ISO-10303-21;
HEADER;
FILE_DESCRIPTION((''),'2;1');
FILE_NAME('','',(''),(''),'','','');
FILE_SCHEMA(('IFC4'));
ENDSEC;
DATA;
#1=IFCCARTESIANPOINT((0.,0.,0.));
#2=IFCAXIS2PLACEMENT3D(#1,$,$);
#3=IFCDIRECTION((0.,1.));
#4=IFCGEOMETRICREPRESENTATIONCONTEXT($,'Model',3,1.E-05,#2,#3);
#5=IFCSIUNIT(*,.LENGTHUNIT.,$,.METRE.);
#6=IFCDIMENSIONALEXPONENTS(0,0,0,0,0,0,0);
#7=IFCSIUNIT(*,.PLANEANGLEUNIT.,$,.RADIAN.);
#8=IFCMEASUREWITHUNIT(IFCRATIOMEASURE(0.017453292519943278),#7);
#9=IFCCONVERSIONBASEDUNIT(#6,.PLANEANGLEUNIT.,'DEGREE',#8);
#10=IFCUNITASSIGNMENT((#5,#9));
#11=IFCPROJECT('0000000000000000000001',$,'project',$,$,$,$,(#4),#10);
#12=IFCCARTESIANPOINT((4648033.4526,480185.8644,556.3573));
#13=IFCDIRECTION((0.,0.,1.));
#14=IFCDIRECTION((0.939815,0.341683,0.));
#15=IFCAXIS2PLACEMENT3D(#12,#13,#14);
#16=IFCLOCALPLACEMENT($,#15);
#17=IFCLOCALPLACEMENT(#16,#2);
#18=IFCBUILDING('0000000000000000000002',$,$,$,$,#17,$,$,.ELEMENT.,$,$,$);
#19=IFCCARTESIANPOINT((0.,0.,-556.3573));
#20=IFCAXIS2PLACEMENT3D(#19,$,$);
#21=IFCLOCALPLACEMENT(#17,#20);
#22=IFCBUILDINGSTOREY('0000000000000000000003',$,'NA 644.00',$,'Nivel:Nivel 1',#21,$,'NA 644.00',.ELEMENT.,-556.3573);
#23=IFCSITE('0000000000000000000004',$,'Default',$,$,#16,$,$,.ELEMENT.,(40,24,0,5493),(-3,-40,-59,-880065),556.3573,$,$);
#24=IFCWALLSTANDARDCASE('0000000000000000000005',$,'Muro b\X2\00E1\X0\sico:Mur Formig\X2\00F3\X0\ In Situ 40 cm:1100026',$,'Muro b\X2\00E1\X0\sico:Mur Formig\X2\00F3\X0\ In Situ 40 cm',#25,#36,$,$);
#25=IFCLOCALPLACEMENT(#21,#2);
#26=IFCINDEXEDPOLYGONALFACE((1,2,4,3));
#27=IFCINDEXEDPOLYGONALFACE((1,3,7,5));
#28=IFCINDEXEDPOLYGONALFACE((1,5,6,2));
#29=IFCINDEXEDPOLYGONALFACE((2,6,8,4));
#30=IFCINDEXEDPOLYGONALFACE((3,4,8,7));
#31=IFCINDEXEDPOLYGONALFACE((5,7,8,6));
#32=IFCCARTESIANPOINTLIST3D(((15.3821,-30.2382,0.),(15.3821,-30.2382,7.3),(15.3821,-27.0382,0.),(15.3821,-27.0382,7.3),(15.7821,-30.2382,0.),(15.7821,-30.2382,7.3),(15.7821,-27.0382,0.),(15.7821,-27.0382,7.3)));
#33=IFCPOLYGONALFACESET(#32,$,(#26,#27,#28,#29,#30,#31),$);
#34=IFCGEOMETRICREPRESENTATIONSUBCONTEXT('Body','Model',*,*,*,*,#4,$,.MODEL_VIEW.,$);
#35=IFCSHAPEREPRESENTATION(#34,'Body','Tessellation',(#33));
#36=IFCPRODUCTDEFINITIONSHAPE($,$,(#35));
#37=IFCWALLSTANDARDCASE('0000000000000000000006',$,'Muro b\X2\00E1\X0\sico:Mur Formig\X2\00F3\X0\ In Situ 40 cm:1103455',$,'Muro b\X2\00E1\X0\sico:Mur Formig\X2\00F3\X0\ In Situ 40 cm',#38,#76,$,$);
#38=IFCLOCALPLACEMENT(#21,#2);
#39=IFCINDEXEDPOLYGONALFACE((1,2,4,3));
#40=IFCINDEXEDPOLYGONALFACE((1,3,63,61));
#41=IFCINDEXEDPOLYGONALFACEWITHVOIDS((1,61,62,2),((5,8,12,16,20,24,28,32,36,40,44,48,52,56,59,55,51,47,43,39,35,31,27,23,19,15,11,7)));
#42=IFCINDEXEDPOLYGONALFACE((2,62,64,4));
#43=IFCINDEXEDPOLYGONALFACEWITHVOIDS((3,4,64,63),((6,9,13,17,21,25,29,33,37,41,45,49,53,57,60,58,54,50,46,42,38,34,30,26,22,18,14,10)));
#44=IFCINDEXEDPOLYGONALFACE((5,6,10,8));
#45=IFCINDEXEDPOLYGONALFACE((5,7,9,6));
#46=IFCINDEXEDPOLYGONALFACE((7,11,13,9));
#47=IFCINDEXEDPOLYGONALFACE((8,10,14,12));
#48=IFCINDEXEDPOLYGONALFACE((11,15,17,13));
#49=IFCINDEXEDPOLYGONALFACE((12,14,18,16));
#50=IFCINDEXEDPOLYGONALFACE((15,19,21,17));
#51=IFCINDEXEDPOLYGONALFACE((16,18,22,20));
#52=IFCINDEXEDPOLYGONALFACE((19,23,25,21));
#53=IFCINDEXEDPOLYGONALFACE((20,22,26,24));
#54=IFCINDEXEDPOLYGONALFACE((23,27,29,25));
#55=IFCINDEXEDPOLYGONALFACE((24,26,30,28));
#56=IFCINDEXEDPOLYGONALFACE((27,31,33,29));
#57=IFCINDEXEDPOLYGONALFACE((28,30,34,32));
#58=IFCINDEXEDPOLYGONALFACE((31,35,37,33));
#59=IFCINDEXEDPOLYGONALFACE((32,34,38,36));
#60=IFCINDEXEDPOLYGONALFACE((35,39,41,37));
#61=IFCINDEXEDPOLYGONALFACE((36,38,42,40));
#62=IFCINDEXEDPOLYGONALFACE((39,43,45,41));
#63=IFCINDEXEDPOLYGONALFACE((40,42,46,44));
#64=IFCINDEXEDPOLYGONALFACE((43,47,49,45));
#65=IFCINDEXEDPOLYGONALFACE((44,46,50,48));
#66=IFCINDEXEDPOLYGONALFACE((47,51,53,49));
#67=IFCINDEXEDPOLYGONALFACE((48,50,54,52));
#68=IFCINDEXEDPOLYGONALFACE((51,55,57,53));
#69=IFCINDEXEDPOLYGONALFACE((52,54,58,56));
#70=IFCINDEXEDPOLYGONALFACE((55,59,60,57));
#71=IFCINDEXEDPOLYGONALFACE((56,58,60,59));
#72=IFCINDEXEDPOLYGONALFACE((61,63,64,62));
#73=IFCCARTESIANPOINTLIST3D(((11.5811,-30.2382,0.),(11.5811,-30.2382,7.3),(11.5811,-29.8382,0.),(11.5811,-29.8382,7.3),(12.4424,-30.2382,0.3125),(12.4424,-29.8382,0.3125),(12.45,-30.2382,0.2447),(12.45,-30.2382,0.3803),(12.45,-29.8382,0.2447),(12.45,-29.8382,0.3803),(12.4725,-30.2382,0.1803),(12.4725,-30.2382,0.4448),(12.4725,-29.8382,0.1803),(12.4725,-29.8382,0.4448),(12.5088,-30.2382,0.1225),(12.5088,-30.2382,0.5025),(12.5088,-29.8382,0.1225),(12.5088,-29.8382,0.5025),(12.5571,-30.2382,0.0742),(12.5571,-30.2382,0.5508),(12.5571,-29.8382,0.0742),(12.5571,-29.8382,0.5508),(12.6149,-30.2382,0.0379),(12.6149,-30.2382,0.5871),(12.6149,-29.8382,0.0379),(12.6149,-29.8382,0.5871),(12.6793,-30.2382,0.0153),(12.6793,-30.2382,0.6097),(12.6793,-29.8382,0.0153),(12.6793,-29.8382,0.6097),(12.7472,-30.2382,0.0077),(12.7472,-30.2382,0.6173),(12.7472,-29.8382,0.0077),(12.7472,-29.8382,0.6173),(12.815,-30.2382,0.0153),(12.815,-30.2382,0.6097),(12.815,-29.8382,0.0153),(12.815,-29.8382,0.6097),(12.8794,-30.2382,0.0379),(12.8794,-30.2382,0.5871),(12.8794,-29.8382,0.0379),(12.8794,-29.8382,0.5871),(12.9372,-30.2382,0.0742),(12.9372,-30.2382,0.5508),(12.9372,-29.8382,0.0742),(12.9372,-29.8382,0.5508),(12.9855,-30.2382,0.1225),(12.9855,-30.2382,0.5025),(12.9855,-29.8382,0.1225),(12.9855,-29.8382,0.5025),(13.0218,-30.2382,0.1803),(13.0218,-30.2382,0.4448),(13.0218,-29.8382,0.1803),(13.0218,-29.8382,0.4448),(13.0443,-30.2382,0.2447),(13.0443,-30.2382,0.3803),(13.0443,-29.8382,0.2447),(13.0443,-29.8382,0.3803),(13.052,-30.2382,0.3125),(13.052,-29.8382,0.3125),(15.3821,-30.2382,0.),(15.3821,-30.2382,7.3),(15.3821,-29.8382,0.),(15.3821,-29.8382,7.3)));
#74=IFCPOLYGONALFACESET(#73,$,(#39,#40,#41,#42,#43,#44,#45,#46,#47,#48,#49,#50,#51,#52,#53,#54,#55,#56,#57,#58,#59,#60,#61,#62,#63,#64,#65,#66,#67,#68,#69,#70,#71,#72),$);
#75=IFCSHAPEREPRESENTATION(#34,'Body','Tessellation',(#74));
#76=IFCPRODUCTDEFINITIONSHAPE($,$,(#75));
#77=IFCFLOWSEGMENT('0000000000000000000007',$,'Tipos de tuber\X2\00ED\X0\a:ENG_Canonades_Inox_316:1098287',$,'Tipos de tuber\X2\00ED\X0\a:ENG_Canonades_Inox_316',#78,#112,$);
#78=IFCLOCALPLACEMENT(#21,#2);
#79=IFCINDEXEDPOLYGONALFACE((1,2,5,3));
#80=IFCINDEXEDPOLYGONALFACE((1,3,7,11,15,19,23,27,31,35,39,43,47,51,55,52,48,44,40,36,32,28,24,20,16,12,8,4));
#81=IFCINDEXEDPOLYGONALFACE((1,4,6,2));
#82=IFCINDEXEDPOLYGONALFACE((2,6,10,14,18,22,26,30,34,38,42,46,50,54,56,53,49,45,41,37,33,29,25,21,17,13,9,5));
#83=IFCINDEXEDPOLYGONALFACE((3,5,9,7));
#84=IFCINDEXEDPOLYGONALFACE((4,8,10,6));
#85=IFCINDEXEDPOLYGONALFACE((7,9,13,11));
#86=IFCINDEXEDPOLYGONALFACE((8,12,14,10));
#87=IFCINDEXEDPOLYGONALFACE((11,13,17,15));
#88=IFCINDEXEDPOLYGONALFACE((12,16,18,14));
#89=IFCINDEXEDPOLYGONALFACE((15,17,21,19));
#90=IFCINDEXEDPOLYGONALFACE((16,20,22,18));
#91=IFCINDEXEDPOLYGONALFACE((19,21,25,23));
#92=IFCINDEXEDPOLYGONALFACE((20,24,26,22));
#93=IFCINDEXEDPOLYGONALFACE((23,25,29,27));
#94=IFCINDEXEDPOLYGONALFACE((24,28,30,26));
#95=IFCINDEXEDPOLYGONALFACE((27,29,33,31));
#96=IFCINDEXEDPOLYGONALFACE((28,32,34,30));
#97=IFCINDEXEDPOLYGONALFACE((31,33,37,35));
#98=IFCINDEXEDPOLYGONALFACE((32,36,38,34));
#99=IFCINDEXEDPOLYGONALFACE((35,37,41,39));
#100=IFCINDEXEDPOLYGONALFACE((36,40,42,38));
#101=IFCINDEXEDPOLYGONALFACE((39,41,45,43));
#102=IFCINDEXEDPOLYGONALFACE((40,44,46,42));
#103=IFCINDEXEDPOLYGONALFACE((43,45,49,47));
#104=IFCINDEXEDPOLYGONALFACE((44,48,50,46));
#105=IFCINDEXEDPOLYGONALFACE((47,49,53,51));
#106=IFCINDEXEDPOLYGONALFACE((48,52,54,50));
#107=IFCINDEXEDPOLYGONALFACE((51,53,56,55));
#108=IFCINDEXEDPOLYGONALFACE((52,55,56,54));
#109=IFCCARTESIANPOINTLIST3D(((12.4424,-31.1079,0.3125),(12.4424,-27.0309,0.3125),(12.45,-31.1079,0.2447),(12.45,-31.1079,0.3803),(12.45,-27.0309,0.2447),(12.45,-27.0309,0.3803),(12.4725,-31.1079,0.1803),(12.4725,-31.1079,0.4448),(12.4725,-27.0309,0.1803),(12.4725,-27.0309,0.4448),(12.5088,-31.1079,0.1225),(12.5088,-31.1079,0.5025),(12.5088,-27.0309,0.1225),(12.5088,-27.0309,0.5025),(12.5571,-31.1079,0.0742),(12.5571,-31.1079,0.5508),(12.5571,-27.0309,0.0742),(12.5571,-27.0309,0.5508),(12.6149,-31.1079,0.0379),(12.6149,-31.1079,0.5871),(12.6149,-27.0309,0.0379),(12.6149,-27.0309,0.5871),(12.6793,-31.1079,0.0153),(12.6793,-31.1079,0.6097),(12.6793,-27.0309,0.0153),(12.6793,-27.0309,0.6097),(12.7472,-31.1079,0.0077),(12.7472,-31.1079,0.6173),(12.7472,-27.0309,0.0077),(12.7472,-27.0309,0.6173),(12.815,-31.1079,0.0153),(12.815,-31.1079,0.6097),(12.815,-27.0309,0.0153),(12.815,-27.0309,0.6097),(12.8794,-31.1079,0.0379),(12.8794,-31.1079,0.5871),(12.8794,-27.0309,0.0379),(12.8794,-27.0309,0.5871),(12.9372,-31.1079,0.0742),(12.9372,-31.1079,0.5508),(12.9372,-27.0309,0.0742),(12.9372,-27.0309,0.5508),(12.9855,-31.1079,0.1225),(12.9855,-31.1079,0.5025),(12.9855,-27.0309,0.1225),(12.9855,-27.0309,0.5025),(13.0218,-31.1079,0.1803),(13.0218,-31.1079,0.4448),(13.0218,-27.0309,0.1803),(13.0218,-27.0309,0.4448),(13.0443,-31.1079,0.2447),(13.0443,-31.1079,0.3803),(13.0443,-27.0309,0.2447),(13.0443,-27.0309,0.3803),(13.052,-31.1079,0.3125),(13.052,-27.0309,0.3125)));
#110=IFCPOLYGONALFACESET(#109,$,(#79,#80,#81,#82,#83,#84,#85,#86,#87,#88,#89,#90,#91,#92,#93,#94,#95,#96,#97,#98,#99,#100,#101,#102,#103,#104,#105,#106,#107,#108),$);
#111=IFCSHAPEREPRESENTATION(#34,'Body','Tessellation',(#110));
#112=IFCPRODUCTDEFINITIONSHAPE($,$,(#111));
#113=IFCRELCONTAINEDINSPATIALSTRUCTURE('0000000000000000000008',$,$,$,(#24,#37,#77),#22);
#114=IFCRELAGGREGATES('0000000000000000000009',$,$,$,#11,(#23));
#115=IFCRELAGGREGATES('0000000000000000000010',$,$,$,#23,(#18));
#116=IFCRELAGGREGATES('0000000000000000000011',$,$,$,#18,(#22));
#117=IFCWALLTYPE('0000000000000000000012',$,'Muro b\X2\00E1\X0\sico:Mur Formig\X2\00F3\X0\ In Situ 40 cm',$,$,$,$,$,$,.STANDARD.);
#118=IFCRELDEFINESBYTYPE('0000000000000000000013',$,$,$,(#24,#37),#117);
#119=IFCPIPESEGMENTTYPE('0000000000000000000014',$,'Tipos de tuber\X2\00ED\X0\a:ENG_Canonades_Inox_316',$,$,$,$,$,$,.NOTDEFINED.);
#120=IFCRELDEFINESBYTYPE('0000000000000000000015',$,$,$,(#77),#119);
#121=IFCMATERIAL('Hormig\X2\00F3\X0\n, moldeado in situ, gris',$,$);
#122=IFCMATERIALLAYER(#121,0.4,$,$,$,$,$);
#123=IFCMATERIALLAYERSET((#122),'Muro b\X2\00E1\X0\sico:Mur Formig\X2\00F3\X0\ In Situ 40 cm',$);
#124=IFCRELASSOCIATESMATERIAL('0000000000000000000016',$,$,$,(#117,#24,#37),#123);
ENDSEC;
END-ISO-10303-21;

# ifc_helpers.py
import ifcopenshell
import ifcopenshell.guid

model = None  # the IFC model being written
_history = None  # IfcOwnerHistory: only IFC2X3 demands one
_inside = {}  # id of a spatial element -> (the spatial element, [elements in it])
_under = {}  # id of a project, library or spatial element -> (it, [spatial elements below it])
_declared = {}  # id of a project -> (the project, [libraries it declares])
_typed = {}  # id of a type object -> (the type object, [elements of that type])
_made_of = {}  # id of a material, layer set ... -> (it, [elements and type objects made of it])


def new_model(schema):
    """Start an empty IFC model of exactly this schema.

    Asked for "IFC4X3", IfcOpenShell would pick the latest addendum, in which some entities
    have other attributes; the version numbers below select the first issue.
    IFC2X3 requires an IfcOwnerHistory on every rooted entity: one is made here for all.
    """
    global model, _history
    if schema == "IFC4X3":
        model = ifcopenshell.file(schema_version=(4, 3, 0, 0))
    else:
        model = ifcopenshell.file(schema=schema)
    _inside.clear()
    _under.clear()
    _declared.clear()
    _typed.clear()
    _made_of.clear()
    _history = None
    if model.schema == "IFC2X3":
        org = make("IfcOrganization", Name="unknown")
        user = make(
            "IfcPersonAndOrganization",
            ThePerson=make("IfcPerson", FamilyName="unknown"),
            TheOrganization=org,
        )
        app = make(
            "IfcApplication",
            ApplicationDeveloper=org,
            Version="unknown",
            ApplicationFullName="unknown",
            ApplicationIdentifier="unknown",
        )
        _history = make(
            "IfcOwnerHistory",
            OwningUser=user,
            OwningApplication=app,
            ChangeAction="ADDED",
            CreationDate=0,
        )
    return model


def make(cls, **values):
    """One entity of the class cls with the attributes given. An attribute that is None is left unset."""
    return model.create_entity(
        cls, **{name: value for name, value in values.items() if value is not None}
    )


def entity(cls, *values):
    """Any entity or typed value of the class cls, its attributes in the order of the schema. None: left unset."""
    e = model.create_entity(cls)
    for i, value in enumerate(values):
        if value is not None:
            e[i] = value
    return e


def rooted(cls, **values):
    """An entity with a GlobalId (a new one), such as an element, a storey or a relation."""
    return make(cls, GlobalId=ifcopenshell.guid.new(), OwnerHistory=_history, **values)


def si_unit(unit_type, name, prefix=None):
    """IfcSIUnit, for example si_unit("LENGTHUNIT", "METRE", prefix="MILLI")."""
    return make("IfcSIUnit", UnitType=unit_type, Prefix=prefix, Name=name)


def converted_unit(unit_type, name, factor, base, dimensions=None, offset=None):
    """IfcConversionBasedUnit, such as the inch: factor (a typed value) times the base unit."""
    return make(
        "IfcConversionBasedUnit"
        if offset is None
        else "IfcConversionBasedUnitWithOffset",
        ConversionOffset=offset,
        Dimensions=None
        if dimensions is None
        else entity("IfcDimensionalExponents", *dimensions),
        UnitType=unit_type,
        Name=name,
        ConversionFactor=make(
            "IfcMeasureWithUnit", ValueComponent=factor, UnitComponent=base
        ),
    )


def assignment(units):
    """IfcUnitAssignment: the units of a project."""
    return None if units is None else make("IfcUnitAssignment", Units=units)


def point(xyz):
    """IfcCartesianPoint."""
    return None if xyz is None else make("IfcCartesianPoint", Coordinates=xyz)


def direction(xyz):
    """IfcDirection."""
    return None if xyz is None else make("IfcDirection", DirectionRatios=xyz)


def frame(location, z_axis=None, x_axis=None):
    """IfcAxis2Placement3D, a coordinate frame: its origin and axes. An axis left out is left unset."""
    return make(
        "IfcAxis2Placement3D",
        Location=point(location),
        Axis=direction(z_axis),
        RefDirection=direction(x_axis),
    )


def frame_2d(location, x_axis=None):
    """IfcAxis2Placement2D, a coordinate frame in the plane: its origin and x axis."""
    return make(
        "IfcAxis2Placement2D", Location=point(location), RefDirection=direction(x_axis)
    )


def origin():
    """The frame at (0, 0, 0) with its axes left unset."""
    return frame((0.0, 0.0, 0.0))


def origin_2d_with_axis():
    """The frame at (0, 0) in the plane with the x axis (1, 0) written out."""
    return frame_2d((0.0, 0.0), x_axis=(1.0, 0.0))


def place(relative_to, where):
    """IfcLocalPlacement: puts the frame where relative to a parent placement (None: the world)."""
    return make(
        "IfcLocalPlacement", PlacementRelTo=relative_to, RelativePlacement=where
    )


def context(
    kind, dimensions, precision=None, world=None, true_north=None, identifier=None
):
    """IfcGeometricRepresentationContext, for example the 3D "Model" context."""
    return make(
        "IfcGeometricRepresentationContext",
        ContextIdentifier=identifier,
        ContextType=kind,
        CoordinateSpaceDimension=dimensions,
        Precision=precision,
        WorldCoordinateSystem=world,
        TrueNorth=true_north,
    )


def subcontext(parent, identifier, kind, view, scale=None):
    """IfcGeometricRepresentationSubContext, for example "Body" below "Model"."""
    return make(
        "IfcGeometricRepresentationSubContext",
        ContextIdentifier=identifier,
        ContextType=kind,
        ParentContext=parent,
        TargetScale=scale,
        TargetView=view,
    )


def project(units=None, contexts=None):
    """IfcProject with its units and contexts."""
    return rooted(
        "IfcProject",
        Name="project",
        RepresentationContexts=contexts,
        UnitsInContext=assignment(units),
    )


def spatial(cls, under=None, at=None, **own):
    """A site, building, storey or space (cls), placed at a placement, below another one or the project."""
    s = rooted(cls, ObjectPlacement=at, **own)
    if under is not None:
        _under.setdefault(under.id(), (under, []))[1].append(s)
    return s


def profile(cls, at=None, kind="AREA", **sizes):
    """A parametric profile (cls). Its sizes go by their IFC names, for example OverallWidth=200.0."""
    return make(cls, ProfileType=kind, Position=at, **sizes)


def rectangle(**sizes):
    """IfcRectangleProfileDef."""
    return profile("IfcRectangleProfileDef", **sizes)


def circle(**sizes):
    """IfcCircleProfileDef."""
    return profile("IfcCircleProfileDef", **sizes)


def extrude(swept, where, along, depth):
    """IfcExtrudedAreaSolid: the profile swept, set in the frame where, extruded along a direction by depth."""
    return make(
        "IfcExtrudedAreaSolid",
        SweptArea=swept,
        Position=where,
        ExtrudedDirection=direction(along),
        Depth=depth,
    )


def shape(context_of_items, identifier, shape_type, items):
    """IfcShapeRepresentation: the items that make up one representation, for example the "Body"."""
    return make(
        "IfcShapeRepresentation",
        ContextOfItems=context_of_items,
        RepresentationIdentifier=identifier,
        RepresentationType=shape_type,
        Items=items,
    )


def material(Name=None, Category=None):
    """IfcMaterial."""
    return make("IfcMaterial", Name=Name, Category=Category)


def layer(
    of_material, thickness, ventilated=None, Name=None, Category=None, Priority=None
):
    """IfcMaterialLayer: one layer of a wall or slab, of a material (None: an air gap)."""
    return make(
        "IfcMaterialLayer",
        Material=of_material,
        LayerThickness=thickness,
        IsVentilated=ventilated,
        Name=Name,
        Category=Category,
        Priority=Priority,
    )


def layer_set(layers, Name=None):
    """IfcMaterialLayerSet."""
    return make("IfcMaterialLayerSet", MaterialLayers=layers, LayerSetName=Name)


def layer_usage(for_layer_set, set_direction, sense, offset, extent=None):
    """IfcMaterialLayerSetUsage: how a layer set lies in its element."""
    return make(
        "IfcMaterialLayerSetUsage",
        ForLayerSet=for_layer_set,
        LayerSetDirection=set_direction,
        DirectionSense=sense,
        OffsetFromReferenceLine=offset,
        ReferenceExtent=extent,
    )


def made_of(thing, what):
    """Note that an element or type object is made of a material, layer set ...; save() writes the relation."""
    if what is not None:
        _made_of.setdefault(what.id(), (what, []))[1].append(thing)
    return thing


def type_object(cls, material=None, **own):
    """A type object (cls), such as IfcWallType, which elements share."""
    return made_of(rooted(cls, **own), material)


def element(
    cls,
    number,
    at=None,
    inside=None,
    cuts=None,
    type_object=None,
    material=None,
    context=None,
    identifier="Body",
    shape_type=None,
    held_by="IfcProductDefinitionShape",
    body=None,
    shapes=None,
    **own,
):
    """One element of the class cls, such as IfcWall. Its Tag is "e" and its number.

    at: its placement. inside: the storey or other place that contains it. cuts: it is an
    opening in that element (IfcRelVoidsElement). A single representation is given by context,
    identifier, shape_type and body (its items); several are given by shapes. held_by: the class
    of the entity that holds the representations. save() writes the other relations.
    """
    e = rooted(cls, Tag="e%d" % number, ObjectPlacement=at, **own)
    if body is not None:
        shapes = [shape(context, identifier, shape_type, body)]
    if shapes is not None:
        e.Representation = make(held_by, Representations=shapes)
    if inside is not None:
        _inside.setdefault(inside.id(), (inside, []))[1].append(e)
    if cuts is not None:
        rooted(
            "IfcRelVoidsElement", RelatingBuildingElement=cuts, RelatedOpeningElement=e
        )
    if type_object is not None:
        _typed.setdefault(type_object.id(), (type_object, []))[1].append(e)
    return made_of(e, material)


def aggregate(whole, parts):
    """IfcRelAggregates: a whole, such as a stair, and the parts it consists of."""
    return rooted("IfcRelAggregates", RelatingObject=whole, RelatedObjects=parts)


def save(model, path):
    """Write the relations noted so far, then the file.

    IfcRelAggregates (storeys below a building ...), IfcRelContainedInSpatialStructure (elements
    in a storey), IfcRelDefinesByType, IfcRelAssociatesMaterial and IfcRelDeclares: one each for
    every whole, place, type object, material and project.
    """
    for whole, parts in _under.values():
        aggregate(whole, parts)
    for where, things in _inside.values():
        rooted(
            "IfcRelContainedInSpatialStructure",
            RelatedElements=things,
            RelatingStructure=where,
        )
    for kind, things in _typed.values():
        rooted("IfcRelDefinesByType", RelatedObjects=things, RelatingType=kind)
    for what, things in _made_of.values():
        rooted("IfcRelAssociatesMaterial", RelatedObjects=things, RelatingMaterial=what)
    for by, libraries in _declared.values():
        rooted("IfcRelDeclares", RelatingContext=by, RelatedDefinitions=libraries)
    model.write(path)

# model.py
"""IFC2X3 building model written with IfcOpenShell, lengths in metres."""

from ifc_helpers import new_model, entity, si_unit, converted_unit, direction, frame, frame_2d, origin, origin_2d_with_axis, place, context, subcontext, project, spatial, rectangle, circle, extrude, material, layer, layer_set, layer_usage, type_object, element, save


model = new_model("IFC2X3")

# Units and contexts
model_context = context("Model", 3, precision=1e-05, world=origin(), true_north=direction((0.0, 1.0)))
body_context = subcontext(model_context, "Body", "Model", "MODEL_VIEW")
ifc_project = project(units=[si_unit("LENGTHUNIT", "METRE"), converted_unit("PLANEANGLEUNIT", "DEGREE", entity("IfcRatioMeasure", 0.017453292519943278), si_unit("PLANEANGLEUNIT", "RADIAN"), dimensions=[0, 0, 0, 0, 0, 0, 0])], contexts=[model_context])

# Site, building, storey
site_placement = place(None, frame((4648033.4526, 480185.8644, 556.3573), z_axis=(0.0, 0.0, 1.0), x_axis=(0.939815, 0.341683, 0.0)))
site = spatial("IfcSite", under=ifc_project, at=site_placement, Name="Default", CompositionType="ELEMENT", RefLatitude=(40, 24, 0, 5493), RefLongitude=(-3, -40, -59, -880065), RefElevation=556.3573)
building_placement = place(site_placement, origin())
building = spatial("IfcBuilding", under=site, at=building_placement, CompositionType="ELEMENT")
storey_placement = place(building_placement, frame((0.0, 0.0, -556.3573)))
storey = spatial("IfcBuildingStorey", under=building, at=storey_placement, Name="NA 644.00", ObjectType="Nivel:Nivel 1", LongName="NA 644.00", CompositionType="ELEMENT", Elevation=-556.3573)

# Shared definitions
ifc_material_1 = material(Name="Hormigón, moldeado in situ, gris")

# Shared definitions
ifc_layer_1 = layer(ifc_material_1, 0.4)
ifc_layer_set_1 = layer_set([ifc_layer_1], Name="Muro básico:Mur Formigó In Situ 40 cm")
wall_type = type_object("IfcWallType", Name="Muro básico:Mur Formigó In Situ 40 cm", PredefinedType="STANDARD", material=ifc_layer_set_1)

# Wall
ifc_layer_usage_1 = layer_usage(ifc_layer_set_1, "AXIS2", "NEGATIVE", 0.2)
wall_1_placement = place(storey_placement, frame((15.5821, -27.0382, 0.0), z_axis=(0.0, 0.0, 1.0), x_axis=(0.0, -1.0, 0.0)))
element("IfcWallStandardCase", 1, at=wall_1_placement, inside=storey, type_object=wall_type, material=ifc_layer_usage_1, Name="Muro básico:Mur Formigó In Situ 40 cm:1100026", ObjectType="Muro básico:Mur Formigó In Situ 40 cm", context=body_context, shape_type="SweptSolid", body=[
    extrude(rectangle(XDim=3.2, YDim=0.4, at=frame_2d((1.6, 0.0), x_axis=(-1.0, 0.0))), origin(), (0.0, 0.0, 1.0), 7.3),
])

# Wall, opening
ifc_layer_usage_2 = layer_usage(ifc_layer_set_1, "AXIS2", "NEGATIVE", 0.2)
wall_2_placement = place(storey_placement, frame((11.5811, -30.0382, 0.0)))
wall_2 = element("IfcWallStandardCase", 2, at=wall_2_placement, inside=storey, type_object=wall_type, material=ifc_layer_usage_2, Name="Muro básico:Mur Formigó In Situ 40 cm:1103455", ObjectType="Muro básico:Mur Formigó In Situ 40 cm", context=body_context, shape_type="SweptSolid", body=[
    extrude(rectangle(XDim=3.801, YDim=0.4, at=frame_2d((1.9005, 0.0), x_axis=(-1.0, 0.0))), origin(), (0.0, 0.0, 1.0), 7.3),
])
opening_1_placement = place(wall_2_placement, origin())
element("IfcOpeningElement", 3, at=opening_1_placement, cuts=wall_2, ObjectType="Opening", context=body_context, shape_type="SweptSolid", body=[
    extrude(circle(Radius=0.3048, at=origin_2d_with_axis()), frame((1.166, 0.2, 0.3125), z_axis=(0.0, -1.0, 0.0), x_axis=(-1.0, 0.0, 0.0)), (0.0, 0.0, 1.0), 0.4),
])

# Flow segment
pipe_segment_type = type_object("IfcPipeSegmentType", Name="Tipos de tubería:ENG_Canonades_Inox_316", PredefinedType="NOTDEFINED")
flow_segment_placement = place(storey_placement, origin())
element("IfcFlowSegment", 4, at=flow_segment_placement, inside=storey, type_object=pipe_segment_type, Name="Tipos de tubería:ENG_Canonades_Inox_316:1098287", ObjectType="Tipos de tubería:ENG_Canonades_Inox_316", context=body_context, shape_type="SweptSolid", body=[
    extrude(circle(Radius=0.3048, at=frame_2d((0.0, 0.0), x_axis=(1.0, 0.0))), frame((12.7472, -31.1079, 0.3125), z_axis=(0.0, 1.0, 0.0), x_axis=(-1.0, 0.0, 0.0)), (0.0, 0.0, 1.0), 4.077),
])

save(model, "model.ifc")
